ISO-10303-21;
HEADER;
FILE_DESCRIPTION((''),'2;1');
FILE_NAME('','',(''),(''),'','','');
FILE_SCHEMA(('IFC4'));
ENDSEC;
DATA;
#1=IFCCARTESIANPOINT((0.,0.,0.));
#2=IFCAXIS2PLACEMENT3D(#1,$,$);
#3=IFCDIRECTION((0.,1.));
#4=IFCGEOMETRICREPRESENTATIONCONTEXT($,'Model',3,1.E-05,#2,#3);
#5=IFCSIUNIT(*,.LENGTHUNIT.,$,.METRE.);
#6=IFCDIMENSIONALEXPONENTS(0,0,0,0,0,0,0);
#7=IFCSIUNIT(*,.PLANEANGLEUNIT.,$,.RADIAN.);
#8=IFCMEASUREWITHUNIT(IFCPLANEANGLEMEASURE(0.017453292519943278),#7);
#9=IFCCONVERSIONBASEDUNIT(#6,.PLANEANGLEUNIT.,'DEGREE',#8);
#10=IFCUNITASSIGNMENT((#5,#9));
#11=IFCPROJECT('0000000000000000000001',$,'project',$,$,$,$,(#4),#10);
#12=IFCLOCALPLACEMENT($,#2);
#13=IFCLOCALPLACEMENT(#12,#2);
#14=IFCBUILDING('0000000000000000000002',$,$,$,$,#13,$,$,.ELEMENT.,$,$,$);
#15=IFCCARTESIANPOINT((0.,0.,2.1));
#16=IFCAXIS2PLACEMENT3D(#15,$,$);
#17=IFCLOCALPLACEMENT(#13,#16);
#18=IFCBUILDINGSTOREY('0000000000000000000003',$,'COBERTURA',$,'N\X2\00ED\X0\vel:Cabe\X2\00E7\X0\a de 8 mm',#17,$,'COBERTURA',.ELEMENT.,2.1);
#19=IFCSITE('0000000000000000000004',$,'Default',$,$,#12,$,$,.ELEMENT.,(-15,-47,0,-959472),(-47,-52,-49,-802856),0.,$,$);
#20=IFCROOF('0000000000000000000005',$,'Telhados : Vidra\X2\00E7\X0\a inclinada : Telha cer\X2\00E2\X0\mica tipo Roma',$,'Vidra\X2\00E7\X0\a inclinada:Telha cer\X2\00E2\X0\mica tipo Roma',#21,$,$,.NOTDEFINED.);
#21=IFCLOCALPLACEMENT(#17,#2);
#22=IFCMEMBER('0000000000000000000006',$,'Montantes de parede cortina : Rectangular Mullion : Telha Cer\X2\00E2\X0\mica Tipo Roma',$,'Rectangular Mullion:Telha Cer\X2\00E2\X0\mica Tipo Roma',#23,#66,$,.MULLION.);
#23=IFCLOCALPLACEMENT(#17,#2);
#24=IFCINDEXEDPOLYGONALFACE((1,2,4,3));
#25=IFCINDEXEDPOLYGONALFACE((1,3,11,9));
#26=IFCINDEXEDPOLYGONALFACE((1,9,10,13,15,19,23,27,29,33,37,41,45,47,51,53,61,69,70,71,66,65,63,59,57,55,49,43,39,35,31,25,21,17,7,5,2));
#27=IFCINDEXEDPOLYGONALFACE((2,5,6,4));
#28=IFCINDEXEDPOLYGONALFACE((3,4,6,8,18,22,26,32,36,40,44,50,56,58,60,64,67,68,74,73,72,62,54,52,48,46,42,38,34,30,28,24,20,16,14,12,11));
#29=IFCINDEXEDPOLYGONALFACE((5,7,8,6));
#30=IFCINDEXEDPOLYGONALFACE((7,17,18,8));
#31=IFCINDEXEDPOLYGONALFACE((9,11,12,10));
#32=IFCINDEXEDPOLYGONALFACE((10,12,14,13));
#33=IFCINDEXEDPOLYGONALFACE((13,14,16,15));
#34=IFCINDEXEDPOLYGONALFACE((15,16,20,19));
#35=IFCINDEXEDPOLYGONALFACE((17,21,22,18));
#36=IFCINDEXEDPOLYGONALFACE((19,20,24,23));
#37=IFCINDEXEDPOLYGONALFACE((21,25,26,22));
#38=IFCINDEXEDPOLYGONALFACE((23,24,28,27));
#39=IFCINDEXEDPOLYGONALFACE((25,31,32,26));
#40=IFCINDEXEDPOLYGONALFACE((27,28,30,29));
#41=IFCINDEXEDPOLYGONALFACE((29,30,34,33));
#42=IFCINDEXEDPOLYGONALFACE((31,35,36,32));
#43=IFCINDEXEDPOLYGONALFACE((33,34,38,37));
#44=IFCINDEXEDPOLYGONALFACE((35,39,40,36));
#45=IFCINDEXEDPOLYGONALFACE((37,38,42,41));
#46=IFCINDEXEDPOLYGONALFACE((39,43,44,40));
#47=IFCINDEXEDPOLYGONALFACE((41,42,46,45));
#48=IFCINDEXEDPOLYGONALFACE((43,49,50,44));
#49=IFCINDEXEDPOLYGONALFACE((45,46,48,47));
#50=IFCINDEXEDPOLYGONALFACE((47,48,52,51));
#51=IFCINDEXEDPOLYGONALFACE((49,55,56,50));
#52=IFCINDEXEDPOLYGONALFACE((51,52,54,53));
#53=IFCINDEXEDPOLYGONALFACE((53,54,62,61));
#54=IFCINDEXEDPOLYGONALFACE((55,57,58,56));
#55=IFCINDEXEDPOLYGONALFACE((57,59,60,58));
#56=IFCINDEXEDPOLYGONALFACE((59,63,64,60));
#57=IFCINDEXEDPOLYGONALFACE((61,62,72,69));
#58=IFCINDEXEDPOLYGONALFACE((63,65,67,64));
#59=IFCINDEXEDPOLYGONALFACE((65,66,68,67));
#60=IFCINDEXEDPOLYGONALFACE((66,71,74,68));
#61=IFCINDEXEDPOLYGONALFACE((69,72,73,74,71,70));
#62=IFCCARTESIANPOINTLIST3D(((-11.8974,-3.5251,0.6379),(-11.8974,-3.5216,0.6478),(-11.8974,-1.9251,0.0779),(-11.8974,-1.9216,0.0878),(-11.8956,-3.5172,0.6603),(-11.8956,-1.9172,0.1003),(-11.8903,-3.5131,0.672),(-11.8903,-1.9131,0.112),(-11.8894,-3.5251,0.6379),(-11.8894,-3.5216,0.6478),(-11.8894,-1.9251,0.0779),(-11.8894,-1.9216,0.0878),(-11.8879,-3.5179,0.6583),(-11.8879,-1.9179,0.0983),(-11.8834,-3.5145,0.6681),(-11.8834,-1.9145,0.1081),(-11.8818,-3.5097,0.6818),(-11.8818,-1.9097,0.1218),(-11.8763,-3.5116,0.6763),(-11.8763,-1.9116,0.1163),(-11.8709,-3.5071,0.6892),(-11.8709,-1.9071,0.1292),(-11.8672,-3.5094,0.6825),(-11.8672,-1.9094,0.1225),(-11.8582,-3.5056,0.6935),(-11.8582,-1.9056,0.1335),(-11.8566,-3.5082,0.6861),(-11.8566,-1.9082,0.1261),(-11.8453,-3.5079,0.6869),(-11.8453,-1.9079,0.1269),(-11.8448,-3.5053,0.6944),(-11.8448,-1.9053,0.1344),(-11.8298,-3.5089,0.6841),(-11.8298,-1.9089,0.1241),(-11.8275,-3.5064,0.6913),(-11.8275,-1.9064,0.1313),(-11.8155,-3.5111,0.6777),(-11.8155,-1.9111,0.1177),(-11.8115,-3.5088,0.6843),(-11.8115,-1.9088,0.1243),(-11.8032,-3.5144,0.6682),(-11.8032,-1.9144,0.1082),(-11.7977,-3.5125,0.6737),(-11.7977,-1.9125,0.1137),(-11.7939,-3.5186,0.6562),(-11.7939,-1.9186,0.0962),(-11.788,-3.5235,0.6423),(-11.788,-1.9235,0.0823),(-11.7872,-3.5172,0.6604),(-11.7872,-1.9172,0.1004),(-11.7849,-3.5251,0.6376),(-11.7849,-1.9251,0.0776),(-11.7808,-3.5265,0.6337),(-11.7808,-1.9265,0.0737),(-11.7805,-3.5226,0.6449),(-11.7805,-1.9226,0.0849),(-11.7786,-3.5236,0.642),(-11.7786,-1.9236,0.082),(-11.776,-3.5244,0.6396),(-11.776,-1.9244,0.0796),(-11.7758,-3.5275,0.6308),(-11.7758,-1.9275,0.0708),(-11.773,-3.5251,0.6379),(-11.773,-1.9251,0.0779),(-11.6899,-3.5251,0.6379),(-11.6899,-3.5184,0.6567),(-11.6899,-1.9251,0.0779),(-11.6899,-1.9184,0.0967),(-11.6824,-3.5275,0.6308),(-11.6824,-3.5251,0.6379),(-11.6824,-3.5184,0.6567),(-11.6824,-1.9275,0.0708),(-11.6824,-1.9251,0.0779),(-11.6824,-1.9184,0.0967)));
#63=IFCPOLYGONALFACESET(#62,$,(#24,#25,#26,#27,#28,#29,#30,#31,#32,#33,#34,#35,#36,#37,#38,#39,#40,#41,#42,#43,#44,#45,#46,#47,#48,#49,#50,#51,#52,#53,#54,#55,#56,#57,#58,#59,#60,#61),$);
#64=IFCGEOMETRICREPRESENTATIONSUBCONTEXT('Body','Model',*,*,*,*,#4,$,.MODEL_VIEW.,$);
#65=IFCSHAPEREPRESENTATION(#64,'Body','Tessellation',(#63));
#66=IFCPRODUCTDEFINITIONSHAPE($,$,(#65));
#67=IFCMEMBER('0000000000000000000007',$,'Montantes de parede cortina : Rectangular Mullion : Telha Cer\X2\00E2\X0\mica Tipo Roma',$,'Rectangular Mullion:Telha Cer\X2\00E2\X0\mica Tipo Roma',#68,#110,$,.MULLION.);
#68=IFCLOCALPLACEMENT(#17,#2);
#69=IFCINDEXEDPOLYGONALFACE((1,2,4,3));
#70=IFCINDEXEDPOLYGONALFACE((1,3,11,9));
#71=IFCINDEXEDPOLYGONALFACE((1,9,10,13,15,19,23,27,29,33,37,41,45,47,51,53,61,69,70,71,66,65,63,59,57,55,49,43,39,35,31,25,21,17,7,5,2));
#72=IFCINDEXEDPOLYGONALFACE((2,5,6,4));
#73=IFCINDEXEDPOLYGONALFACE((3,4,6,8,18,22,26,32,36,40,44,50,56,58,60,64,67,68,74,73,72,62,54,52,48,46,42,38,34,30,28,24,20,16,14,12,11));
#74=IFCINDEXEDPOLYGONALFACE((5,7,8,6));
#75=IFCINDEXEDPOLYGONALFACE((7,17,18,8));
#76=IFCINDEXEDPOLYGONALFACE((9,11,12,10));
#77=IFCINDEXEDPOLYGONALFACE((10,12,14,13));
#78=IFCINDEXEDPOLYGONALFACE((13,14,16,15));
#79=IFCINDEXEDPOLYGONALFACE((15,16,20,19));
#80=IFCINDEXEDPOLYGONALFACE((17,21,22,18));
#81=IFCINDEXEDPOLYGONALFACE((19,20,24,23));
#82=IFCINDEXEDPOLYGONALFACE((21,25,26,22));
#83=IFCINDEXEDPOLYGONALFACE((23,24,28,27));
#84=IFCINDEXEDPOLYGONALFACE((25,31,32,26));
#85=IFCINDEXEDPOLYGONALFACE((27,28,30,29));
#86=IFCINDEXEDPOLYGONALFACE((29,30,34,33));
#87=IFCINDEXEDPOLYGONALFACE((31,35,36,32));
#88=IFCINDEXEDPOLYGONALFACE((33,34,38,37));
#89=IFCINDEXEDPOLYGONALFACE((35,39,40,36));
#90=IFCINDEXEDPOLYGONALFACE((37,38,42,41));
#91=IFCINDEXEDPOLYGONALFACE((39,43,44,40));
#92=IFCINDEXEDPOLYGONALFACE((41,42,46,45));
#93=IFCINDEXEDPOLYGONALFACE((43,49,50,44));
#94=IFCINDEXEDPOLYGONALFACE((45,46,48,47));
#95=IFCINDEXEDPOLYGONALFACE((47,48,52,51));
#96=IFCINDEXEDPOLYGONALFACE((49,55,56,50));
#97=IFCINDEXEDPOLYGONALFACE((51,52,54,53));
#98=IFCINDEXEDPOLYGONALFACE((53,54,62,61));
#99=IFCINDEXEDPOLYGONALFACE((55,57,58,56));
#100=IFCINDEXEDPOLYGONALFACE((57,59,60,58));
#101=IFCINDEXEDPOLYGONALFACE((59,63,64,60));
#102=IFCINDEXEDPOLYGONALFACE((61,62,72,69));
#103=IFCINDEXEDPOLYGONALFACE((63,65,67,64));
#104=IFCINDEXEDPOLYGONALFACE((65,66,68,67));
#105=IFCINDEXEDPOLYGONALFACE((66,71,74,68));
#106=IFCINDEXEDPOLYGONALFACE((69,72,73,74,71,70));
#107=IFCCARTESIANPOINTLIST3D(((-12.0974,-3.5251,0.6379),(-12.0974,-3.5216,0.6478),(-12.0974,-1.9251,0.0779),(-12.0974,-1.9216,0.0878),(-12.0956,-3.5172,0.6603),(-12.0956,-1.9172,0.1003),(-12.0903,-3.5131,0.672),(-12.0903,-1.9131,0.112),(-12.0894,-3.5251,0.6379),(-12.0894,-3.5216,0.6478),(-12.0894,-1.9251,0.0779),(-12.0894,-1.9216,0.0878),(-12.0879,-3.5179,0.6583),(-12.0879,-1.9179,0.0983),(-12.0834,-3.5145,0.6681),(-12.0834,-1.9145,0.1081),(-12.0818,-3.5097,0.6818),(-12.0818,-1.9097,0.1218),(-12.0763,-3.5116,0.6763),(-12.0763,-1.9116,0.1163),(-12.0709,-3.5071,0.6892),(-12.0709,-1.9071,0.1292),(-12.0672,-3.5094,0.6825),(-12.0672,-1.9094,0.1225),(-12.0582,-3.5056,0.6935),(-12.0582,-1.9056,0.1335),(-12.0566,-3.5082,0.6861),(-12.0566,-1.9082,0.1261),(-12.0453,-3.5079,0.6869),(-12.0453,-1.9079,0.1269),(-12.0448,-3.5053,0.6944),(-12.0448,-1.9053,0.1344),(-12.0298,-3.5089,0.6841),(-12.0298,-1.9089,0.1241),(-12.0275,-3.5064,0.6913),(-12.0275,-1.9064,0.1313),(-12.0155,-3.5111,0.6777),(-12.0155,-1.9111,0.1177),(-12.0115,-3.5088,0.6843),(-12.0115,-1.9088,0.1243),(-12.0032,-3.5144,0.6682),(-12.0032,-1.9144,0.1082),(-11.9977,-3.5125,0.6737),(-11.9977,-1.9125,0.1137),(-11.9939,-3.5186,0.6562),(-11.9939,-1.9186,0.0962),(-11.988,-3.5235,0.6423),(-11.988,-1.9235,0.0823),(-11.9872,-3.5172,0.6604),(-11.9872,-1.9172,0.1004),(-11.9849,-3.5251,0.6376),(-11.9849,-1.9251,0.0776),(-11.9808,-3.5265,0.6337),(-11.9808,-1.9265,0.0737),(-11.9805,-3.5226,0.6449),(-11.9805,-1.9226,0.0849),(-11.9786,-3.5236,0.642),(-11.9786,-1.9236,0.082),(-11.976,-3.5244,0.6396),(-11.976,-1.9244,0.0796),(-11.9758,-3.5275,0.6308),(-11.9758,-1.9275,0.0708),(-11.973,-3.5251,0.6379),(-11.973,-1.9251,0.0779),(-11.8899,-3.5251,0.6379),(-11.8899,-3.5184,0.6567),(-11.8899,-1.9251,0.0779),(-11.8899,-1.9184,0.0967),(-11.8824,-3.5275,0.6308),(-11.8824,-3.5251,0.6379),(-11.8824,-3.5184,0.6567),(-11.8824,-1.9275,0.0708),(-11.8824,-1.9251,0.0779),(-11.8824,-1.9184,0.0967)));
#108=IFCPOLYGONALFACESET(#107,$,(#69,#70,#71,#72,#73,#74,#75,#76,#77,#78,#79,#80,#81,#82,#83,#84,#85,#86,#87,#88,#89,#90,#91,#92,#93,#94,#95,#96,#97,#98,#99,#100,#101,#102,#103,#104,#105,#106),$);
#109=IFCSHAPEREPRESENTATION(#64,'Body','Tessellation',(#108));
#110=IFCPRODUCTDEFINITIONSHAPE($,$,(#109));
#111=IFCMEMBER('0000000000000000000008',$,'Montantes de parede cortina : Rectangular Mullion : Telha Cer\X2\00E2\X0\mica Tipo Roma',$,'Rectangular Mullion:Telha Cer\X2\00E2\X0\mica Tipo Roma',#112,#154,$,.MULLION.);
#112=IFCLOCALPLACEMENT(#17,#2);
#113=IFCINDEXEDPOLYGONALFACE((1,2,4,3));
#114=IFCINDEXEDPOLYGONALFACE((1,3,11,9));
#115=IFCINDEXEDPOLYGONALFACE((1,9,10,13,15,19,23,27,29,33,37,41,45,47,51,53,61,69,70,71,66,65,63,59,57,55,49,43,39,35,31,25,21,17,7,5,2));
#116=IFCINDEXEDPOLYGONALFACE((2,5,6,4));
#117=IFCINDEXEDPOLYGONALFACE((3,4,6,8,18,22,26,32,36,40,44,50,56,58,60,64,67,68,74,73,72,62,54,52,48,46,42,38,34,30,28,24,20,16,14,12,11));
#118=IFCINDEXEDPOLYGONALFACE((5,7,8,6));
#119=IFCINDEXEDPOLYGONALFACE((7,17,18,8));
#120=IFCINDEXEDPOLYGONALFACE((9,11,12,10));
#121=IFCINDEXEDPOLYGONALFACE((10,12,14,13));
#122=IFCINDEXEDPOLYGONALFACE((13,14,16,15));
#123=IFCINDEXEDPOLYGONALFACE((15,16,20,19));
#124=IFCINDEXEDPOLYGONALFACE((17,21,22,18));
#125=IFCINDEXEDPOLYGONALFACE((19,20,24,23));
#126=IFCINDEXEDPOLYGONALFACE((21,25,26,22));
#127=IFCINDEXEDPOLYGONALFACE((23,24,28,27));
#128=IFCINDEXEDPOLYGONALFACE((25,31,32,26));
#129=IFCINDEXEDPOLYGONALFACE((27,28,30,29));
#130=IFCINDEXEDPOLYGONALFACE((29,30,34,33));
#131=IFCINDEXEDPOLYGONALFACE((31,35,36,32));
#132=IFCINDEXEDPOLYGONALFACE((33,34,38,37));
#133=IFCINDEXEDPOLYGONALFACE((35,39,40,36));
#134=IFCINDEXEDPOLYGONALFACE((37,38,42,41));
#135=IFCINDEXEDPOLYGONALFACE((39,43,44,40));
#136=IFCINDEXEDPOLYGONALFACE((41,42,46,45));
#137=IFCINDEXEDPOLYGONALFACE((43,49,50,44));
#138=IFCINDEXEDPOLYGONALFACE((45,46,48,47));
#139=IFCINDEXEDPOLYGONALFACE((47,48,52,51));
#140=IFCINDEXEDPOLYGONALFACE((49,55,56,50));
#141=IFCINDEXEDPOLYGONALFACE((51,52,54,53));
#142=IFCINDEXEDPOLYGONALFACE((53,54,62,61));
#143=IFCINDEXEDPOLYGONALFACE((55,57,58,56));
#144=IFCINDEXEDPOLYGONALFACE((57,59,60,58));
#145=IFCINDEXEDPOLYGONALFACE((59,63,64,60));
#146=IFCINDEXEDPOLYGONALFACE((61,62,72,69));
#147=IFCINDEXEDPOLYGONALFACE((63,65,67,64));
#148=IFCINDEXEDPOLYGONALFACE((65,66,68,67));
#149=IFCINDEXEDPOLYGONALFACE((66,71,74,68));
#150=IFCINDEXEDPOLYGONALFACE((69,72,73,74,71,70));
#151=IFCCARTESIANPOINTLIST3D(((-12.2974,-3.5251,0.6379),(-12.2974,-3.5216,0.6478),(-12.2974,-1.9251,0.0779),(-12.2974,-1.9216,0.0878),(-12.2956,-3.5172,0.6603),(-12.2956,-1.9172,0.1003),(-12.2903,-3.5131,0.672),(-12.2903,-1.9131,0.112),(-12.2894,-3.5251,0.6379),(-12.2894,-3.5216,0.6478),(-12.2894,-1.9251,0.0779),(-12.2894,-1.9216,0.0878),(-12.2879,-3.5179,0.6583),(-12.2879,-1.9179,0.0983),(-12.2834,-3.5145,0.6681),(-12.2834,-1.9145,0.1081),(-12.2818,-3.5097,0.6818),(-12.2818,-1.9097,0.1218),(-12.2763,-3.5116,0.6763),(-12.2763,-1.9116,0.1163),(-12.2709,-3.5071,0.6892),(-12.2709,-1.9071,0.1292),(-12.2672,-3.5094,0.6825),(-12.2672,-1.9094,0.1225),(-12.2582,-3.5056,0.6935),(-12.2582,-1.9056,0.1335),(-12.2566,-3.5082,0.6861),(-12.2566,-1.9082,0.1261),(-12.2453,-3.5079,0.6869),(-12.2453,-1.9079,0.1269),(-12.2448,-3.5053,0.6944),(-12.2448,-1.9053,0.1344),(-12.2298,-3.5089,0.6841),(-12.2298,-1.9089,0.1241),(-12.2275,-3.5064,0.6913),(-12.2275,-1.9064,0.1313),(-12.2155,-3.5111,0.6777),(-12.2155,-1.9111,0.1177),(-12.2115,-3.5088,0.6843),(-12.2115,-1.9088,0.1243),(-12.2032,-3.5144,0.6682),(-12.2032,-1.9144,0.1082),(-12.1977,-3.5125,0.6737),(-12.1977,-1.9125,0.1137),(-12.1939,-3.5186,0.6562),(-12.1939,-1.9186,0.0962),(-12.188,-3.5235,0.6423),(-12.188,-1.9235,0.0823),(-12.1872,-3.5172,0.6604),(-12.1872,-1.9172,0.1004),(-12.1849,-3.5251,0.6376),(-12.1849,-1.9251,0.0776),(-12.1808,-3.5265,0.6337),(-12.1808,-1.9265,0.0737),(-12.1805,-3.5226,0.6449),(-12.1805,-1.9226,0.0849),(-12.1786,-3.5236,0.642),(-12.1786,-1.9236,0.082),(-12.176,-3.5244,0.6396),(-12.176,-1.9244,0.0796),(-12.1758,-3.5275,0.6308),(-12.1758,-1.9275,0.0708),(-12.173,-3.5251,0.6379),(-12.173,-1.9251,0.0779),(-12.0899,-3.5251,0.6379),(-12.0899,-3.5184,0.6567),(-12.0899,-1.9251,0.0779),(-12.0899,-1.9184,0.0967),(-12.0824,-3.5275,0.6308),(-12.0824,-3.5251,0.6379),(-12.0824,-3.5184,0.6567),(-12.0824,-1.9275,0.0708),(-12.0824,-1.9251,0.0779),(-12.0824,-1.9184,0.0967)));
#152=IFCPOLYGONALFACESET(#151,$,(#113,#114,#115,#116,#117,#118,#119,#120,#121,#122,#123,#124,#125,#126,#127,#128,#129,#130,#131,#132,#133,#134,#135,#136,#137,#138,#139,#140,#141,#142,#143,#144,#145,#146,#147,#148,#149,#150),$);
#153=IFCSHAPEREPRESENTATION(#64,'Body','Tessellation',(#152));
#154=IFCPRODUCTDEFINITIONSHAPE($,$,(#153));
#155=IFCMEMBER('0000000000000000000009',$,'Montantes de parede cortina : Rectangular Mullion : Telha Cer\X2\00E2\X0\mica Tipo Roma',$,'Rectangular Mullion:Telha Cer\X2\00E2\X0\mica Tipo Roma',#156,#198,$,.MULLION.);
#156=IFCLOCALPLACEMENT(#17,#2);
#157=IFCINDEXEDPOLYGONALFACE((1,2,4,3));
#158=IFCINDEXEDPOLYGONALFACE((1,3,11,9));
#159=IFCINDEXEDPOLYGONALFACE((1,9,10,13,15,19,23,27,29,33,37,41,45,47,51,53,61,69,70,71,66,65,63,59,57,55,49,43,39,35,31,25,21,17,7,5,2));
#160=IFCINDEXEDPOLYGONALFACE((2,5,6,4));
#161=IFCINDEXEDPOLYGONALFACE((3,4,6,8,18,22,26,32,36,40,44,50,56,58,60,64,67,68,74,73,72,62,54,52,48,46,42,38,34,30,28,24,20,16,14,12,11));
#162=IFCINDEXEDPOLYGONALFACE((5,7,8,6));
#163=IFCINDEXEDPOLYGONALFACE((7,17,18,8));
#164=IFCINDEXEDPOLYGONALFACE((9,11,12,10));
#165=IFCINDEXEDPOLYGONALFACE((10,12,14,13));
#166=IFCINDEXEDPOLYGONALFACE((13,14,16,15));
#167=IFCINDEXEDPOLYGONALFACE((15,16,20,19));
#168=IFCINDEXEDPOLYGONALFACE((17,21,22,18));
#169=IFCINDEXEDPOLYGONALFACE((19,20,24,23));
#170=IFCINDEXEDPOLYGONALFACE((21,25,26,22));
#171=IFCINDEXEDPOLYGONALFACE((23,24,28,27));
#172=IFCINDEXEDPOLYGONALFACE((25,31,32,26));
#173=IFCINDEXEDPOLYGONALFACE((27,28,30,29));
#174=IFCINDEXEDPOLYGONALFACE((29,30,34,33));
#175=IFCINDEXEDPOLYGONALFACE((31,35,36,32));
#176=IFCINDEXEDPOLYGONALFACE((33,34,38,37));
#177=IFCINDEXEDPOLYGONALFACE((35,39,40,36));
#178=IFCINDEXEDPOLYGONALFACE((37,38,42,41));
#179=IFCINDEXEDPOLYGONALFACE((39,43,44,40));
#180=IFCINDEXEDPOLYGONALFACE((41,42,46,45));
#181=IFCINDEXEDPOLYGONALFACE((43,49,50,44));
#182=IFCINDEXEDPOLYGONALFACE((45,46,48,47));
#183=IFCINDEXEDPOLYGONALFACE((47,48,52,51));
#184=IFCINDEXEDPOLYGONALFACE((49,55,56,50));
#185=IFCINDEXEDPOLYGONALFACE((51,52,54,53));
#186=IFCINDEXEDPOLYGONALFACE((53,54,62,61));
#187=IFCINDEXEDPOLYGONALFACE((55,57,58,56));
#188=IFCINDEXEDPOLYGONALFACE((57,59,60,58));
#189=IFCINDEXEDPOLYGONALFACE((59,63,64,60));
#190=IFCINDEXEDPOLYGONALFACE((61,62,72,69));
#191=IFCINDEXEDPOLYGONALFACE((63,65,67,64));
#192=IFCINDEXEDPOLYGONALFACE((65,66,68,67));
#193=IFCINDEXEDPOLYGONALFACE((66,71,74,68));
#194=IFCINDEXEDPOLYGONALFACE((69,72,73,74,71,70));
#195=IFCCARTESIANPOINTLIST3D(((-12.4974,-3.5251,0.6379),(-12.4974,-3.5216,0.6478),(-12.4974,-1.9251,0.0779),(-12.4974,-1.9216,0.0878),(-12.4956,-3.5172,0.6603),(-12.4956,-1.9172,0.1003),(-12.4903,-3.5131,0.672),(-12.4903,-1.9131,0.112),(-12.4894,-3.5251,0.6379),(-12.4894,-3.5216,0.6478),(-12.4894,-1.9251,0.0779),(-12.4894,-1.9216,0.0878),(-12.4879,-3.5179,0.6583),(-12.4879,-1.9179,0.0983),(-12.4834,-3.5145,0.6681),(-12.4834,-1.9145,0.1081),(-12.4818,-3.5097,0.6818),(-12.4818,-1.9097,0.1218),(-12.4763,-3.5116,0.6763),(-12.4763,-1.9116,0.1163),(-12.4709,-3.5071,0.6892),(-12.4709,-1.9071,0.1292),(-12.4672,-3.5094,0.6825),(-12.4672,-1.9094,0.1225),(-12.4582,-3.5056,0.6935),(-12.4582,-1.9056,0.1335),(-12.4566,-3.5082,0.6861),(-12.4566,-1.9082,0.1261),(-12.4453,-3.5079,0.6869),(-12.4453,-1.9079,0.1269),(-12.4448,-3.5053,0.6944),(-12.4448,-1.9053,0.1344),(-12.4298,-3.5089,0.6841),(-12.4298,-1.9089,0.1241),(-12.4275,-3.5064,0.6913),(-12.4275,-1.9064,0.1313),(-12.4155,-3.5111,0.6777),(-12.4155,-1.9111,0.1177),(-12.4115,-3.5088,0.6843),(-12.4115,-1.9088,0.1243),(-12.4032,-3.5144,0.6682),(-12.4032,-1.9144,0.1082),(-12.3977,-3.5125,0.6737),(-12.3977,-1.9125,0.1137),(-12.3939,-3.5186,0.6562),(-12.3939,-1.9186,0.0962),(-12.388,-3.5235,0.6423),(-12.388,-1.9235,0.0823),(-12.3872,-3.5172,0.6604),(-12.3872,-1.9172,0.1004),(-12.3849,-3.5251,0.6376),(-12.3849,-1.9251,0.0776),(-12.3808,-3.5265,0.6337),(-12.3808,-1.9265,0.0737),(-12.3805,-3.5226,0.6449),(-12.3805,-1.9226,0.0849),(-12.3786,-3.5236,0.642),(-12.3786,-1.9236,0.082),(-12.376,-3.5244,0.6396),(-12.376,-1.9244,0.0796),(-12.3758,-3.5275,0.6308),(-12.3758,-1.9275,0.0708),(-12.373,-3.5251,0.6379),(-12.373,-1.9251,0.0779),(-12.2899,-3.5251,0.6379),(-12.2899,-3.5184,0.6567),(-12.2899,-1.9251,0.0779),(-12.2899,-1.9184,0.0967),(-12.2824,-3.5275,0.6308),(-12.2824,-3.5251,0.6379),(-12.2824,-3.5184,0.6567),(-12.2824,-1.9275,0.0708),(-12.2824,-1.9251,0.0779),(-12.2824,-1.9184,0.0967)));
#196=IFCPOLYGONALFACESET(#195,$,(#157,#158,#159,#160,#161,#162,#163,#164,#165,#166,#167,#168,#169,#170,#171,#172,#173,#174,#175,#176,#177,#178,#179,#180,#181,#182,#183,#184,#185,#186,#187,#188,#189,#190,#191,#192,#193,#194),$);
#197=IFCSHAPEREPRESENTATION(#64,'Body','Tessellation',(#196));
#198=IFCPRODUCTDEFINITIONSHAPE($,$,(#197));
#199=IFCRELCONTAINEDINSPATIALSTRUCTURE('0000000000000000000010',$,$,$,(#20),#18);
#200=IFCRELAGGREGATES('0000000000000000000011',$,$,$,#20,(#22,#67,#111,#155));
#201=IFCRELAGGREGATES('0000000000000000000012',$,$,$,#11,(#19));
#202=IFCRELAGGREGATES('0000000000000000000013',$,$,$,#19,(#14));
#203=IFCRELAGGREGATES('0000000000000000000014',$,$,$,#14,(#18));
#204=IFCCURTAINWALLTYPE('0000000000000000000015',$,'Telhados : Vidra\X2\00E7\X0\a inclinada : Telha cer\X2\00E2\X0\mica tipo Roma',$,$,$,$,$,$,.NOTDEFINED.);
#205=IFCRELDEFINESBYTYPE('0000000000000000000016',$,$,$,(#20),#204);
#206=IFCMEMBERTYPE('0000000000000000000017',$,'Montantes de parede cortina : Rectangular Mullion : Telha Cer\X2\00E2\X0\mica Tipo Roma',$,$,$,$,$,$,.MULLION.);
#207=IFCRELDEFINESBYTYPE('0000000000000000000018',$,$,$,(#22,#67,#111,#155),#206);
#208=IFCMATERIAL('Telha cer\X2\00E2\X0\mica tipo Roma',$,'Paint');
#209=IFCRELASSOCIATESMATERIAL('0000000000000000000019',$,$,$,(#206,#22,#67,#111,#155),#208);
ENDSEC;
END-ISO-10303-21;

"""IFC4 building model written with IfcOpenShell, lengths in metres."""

from ifc_helpers import new_model, entity, si_unit, converted_unit, direction, frame, origin, place, context, subcontext, project, spatial, line, arc, indexed_curve, outline, extrude, source, transform, mapped, material, type_object, type_shapes, element, aggregate, save


model = new_model("IFC4")

# Units and contexts
model_context = context("Model", 3, precision=1e-05, world=origin(), true_north=direction((0.0, 1.0)))
body_context = subcontext(model_context, "Body", "Model", "MODEL_VIEW")
ifc_project = project(units=[si_unit("LENGTHUNIT", "METRE"), converted_unit("PLANEANGLEUNIT", "DEGREE", entity("IfcPlaneAngleMeasure", 0.017453292519943278), si_unit("PLANEANGLEUNIT", "RADIAN"), dimensions=[0, 0, 0, 0, 0, 0, 0])], contexts=[model_context])

# Site, building, storey
site_placement = place(None, origin())
site = spatial("IfcSite", under=ifc_project, at=site_placement, Name="Default", CompositionType="ELEMENT", RefLatitude=(-15, -47, 0, -959472), RefLongitude=(-47, -52, -49, -802856), RefElevation=0.0)
building_placement = place(site_placement, origin())
building = spatial("IfcBuilding", under=site, at=building_placement, CompositionType="ELEMENT")
storey_placement = place(building_placement, frame((0.0, 0.0, 2.1)))
storey = spatial("IfcBuildingStorey", under=building, at=storey_placement, Name="COBERTURA", ObjectType="Nível:Cabeça de 8 mm", LongName="COBERTURA", CompositionType="ELEMENT", Elevation=2.1)

# Roof, members
curtain_wall_type_1 = type_object("IfcCurtainWallType", Name="Telhados : Vidraça inclinada : Telha cerâmica tipo Roma", PredefinedType="NOTDEFINED")
roof_1_placement = place(storey_placement, frame((0.0, 0.0, -2.1)))
roof_1 = element("IfcRoof", 1, at=roof_1_placement, inside=storey, type_object=curtain_wall_type_1, Name="Telhados : Vidraça inclinada : Telha cerâmica tipo Roma", ObjectType="Vidraça inclinada:Telha cerâmica tipo Roma", PredefinedType="NOTDEFINED")
ifc_material_1 = material(Name="Telha cerâmica tipo Roma", Category="Paint")
member_type_1 = type_object("IfcMemberType", Name="Montantes de parede cortina : Rectangular Mullion : Telha Cerâmica Tipo Roma", PredefinedType="MULLION", material=ifc_material_1)
shared_shape_1 = source(origin(), body_context, "Body", "SweptSolid", [
    extrude(outline(indexed_curve([(0.0114, -0.0188), (0.1048, -0.0188), (0.1048, -0.0113), (0.1048, 0.0087), (0.0973, 0.0087), (0.0973, -0.0113), (0.0142, -0.0113), (0.0098, -0.0083), (0.0067, -0.0038), (-0.017, 0.0327), (-0.0576, 0.0486), (-0.0946, 0.0352), (-0.1102, -0.0008), (-0.1102, -0.0113), (-0.1022, -0.0113), (-0.1022, -0.0008), (-0.0891, 0.0294), (-0.0581, 0.0406), (-0.0218, 0.0263), (-0.0008, -0.0066), (0.0042, -0.0138)], segments=[line(1, 2, 3, 4, 5, 6, 7), arc(7, 8, 9), arc(9, 10, 11), arc(11, 12, 13), line(13, 14, 15, 16), arc(16, 17, 18), arc(18, 19, 20), arc(20, 21, 1)], self_intersect=False)), frame((-0.0027, -0.0938, -4.3552), z_axis=(0.0, 0.0, 1.0), x_axis=(-1.0, 0.0, 0.0)), (0.0, 0.0, 1.0), 1.6952),
])
type_shapes(member_type_1, [shared_shape_1])
member_1_placement = place(roof_1_placement, frame((-11.7899, -6.063, 3.5387), z_axis=(0.0, -0.943858, 0.33035), x_axis=(-1.0, 0.0, 0.0)))
member_1 = element("IfcMember", 2, at=member_1_placement, type_object=member_type_1, material=ifc_material_1, Name="Montantes de parede cortina : Rectangular Mullion : Telha Cerâmica Tipo Roma", ObjectType="Rectangular Mullion:Telha Cerâmica Tipo Roma", PredefinedType="MULLION", context=body_context, shape_type="MappedRepresentation", body=[
    mapped(shared_shape_1, transform((0.0, 0.0, 0.0), scale=1.0)),
])
member_2_placement = place(roof_1_placement, frame((-11.9899, -6.063, 3.5387), z_axis=(0.0, -0.943858, 0.33035), x_axis=(-1.0, 0.0, 0.0)))
member_2 = element("IfcMember", 3, at=member_2_placement, type_object=member_type_1, material=ifc_material_1, Name="Montantes de parede cortina : Rectangular Mullion : Telha Cerâmica Tipo Roma", ObjectType="Rectangular Mullion:Telha Cerâmica Tipo Roma", PredefinedType="MULLION", context=body_context, shape_type="MappedRepresentation", body=[
    mapped(shared_shape_1, transform((0.0, 0.0, 0.0), scale=1.0)),
])
member_3_placement = place(roof_1_placement, frame((-12.1899, -6.063, 3.5387), z_axis=(0.0, -0.943858, 0.33035), x_axis=(-1.0, 0.0, 0.0)))
member_3 = element("IfcMember", 4, at=member_3_placement, type_object=member_type_1, material=ifc_material_1, Name="Montantes de parede cortina : Rectangular Mullion : Telha Cerâmica Tipo Roma", ObjectType="Rectangular Mullion:Telha Cerâmica Tipo Roma", PredefinedType="MULLION", context=body_context, shape_type="MappedRepresentation", body=[
    mapped(shared_shape_1, transform((0.0, 0.0, 0.0), scale=1.0)),
])
member_4_placement = place(roof_1_placement, frame((-12.3899, -6.063, 3.5387), z_axis=(0.0, -0.943858, 0.33035), x_axis=(-1.0, 0.0, 0.0)))
member_4 = element("IfcMember", 5, at=member_4_placement, type_object=member_type_1, material=ifc_material_1, Name="Montantes de parede cortina : Rectangular Mullion : Telha Cerâmica Tipo Roma", ObjectType="Rectangular Mullion:Telha Cerâmica Tipo Roma", PredefinedType="MULLION", context=body_context, shape_type="MappedRepresentation", body=[
    mapped(shared_shape_1, transform((0.0, 0.0, 0.0), scale=1.0)),
])
aggregate(roof_1, [member_1, member_2, member_3, member_4])

save(model, "model.ifc")
